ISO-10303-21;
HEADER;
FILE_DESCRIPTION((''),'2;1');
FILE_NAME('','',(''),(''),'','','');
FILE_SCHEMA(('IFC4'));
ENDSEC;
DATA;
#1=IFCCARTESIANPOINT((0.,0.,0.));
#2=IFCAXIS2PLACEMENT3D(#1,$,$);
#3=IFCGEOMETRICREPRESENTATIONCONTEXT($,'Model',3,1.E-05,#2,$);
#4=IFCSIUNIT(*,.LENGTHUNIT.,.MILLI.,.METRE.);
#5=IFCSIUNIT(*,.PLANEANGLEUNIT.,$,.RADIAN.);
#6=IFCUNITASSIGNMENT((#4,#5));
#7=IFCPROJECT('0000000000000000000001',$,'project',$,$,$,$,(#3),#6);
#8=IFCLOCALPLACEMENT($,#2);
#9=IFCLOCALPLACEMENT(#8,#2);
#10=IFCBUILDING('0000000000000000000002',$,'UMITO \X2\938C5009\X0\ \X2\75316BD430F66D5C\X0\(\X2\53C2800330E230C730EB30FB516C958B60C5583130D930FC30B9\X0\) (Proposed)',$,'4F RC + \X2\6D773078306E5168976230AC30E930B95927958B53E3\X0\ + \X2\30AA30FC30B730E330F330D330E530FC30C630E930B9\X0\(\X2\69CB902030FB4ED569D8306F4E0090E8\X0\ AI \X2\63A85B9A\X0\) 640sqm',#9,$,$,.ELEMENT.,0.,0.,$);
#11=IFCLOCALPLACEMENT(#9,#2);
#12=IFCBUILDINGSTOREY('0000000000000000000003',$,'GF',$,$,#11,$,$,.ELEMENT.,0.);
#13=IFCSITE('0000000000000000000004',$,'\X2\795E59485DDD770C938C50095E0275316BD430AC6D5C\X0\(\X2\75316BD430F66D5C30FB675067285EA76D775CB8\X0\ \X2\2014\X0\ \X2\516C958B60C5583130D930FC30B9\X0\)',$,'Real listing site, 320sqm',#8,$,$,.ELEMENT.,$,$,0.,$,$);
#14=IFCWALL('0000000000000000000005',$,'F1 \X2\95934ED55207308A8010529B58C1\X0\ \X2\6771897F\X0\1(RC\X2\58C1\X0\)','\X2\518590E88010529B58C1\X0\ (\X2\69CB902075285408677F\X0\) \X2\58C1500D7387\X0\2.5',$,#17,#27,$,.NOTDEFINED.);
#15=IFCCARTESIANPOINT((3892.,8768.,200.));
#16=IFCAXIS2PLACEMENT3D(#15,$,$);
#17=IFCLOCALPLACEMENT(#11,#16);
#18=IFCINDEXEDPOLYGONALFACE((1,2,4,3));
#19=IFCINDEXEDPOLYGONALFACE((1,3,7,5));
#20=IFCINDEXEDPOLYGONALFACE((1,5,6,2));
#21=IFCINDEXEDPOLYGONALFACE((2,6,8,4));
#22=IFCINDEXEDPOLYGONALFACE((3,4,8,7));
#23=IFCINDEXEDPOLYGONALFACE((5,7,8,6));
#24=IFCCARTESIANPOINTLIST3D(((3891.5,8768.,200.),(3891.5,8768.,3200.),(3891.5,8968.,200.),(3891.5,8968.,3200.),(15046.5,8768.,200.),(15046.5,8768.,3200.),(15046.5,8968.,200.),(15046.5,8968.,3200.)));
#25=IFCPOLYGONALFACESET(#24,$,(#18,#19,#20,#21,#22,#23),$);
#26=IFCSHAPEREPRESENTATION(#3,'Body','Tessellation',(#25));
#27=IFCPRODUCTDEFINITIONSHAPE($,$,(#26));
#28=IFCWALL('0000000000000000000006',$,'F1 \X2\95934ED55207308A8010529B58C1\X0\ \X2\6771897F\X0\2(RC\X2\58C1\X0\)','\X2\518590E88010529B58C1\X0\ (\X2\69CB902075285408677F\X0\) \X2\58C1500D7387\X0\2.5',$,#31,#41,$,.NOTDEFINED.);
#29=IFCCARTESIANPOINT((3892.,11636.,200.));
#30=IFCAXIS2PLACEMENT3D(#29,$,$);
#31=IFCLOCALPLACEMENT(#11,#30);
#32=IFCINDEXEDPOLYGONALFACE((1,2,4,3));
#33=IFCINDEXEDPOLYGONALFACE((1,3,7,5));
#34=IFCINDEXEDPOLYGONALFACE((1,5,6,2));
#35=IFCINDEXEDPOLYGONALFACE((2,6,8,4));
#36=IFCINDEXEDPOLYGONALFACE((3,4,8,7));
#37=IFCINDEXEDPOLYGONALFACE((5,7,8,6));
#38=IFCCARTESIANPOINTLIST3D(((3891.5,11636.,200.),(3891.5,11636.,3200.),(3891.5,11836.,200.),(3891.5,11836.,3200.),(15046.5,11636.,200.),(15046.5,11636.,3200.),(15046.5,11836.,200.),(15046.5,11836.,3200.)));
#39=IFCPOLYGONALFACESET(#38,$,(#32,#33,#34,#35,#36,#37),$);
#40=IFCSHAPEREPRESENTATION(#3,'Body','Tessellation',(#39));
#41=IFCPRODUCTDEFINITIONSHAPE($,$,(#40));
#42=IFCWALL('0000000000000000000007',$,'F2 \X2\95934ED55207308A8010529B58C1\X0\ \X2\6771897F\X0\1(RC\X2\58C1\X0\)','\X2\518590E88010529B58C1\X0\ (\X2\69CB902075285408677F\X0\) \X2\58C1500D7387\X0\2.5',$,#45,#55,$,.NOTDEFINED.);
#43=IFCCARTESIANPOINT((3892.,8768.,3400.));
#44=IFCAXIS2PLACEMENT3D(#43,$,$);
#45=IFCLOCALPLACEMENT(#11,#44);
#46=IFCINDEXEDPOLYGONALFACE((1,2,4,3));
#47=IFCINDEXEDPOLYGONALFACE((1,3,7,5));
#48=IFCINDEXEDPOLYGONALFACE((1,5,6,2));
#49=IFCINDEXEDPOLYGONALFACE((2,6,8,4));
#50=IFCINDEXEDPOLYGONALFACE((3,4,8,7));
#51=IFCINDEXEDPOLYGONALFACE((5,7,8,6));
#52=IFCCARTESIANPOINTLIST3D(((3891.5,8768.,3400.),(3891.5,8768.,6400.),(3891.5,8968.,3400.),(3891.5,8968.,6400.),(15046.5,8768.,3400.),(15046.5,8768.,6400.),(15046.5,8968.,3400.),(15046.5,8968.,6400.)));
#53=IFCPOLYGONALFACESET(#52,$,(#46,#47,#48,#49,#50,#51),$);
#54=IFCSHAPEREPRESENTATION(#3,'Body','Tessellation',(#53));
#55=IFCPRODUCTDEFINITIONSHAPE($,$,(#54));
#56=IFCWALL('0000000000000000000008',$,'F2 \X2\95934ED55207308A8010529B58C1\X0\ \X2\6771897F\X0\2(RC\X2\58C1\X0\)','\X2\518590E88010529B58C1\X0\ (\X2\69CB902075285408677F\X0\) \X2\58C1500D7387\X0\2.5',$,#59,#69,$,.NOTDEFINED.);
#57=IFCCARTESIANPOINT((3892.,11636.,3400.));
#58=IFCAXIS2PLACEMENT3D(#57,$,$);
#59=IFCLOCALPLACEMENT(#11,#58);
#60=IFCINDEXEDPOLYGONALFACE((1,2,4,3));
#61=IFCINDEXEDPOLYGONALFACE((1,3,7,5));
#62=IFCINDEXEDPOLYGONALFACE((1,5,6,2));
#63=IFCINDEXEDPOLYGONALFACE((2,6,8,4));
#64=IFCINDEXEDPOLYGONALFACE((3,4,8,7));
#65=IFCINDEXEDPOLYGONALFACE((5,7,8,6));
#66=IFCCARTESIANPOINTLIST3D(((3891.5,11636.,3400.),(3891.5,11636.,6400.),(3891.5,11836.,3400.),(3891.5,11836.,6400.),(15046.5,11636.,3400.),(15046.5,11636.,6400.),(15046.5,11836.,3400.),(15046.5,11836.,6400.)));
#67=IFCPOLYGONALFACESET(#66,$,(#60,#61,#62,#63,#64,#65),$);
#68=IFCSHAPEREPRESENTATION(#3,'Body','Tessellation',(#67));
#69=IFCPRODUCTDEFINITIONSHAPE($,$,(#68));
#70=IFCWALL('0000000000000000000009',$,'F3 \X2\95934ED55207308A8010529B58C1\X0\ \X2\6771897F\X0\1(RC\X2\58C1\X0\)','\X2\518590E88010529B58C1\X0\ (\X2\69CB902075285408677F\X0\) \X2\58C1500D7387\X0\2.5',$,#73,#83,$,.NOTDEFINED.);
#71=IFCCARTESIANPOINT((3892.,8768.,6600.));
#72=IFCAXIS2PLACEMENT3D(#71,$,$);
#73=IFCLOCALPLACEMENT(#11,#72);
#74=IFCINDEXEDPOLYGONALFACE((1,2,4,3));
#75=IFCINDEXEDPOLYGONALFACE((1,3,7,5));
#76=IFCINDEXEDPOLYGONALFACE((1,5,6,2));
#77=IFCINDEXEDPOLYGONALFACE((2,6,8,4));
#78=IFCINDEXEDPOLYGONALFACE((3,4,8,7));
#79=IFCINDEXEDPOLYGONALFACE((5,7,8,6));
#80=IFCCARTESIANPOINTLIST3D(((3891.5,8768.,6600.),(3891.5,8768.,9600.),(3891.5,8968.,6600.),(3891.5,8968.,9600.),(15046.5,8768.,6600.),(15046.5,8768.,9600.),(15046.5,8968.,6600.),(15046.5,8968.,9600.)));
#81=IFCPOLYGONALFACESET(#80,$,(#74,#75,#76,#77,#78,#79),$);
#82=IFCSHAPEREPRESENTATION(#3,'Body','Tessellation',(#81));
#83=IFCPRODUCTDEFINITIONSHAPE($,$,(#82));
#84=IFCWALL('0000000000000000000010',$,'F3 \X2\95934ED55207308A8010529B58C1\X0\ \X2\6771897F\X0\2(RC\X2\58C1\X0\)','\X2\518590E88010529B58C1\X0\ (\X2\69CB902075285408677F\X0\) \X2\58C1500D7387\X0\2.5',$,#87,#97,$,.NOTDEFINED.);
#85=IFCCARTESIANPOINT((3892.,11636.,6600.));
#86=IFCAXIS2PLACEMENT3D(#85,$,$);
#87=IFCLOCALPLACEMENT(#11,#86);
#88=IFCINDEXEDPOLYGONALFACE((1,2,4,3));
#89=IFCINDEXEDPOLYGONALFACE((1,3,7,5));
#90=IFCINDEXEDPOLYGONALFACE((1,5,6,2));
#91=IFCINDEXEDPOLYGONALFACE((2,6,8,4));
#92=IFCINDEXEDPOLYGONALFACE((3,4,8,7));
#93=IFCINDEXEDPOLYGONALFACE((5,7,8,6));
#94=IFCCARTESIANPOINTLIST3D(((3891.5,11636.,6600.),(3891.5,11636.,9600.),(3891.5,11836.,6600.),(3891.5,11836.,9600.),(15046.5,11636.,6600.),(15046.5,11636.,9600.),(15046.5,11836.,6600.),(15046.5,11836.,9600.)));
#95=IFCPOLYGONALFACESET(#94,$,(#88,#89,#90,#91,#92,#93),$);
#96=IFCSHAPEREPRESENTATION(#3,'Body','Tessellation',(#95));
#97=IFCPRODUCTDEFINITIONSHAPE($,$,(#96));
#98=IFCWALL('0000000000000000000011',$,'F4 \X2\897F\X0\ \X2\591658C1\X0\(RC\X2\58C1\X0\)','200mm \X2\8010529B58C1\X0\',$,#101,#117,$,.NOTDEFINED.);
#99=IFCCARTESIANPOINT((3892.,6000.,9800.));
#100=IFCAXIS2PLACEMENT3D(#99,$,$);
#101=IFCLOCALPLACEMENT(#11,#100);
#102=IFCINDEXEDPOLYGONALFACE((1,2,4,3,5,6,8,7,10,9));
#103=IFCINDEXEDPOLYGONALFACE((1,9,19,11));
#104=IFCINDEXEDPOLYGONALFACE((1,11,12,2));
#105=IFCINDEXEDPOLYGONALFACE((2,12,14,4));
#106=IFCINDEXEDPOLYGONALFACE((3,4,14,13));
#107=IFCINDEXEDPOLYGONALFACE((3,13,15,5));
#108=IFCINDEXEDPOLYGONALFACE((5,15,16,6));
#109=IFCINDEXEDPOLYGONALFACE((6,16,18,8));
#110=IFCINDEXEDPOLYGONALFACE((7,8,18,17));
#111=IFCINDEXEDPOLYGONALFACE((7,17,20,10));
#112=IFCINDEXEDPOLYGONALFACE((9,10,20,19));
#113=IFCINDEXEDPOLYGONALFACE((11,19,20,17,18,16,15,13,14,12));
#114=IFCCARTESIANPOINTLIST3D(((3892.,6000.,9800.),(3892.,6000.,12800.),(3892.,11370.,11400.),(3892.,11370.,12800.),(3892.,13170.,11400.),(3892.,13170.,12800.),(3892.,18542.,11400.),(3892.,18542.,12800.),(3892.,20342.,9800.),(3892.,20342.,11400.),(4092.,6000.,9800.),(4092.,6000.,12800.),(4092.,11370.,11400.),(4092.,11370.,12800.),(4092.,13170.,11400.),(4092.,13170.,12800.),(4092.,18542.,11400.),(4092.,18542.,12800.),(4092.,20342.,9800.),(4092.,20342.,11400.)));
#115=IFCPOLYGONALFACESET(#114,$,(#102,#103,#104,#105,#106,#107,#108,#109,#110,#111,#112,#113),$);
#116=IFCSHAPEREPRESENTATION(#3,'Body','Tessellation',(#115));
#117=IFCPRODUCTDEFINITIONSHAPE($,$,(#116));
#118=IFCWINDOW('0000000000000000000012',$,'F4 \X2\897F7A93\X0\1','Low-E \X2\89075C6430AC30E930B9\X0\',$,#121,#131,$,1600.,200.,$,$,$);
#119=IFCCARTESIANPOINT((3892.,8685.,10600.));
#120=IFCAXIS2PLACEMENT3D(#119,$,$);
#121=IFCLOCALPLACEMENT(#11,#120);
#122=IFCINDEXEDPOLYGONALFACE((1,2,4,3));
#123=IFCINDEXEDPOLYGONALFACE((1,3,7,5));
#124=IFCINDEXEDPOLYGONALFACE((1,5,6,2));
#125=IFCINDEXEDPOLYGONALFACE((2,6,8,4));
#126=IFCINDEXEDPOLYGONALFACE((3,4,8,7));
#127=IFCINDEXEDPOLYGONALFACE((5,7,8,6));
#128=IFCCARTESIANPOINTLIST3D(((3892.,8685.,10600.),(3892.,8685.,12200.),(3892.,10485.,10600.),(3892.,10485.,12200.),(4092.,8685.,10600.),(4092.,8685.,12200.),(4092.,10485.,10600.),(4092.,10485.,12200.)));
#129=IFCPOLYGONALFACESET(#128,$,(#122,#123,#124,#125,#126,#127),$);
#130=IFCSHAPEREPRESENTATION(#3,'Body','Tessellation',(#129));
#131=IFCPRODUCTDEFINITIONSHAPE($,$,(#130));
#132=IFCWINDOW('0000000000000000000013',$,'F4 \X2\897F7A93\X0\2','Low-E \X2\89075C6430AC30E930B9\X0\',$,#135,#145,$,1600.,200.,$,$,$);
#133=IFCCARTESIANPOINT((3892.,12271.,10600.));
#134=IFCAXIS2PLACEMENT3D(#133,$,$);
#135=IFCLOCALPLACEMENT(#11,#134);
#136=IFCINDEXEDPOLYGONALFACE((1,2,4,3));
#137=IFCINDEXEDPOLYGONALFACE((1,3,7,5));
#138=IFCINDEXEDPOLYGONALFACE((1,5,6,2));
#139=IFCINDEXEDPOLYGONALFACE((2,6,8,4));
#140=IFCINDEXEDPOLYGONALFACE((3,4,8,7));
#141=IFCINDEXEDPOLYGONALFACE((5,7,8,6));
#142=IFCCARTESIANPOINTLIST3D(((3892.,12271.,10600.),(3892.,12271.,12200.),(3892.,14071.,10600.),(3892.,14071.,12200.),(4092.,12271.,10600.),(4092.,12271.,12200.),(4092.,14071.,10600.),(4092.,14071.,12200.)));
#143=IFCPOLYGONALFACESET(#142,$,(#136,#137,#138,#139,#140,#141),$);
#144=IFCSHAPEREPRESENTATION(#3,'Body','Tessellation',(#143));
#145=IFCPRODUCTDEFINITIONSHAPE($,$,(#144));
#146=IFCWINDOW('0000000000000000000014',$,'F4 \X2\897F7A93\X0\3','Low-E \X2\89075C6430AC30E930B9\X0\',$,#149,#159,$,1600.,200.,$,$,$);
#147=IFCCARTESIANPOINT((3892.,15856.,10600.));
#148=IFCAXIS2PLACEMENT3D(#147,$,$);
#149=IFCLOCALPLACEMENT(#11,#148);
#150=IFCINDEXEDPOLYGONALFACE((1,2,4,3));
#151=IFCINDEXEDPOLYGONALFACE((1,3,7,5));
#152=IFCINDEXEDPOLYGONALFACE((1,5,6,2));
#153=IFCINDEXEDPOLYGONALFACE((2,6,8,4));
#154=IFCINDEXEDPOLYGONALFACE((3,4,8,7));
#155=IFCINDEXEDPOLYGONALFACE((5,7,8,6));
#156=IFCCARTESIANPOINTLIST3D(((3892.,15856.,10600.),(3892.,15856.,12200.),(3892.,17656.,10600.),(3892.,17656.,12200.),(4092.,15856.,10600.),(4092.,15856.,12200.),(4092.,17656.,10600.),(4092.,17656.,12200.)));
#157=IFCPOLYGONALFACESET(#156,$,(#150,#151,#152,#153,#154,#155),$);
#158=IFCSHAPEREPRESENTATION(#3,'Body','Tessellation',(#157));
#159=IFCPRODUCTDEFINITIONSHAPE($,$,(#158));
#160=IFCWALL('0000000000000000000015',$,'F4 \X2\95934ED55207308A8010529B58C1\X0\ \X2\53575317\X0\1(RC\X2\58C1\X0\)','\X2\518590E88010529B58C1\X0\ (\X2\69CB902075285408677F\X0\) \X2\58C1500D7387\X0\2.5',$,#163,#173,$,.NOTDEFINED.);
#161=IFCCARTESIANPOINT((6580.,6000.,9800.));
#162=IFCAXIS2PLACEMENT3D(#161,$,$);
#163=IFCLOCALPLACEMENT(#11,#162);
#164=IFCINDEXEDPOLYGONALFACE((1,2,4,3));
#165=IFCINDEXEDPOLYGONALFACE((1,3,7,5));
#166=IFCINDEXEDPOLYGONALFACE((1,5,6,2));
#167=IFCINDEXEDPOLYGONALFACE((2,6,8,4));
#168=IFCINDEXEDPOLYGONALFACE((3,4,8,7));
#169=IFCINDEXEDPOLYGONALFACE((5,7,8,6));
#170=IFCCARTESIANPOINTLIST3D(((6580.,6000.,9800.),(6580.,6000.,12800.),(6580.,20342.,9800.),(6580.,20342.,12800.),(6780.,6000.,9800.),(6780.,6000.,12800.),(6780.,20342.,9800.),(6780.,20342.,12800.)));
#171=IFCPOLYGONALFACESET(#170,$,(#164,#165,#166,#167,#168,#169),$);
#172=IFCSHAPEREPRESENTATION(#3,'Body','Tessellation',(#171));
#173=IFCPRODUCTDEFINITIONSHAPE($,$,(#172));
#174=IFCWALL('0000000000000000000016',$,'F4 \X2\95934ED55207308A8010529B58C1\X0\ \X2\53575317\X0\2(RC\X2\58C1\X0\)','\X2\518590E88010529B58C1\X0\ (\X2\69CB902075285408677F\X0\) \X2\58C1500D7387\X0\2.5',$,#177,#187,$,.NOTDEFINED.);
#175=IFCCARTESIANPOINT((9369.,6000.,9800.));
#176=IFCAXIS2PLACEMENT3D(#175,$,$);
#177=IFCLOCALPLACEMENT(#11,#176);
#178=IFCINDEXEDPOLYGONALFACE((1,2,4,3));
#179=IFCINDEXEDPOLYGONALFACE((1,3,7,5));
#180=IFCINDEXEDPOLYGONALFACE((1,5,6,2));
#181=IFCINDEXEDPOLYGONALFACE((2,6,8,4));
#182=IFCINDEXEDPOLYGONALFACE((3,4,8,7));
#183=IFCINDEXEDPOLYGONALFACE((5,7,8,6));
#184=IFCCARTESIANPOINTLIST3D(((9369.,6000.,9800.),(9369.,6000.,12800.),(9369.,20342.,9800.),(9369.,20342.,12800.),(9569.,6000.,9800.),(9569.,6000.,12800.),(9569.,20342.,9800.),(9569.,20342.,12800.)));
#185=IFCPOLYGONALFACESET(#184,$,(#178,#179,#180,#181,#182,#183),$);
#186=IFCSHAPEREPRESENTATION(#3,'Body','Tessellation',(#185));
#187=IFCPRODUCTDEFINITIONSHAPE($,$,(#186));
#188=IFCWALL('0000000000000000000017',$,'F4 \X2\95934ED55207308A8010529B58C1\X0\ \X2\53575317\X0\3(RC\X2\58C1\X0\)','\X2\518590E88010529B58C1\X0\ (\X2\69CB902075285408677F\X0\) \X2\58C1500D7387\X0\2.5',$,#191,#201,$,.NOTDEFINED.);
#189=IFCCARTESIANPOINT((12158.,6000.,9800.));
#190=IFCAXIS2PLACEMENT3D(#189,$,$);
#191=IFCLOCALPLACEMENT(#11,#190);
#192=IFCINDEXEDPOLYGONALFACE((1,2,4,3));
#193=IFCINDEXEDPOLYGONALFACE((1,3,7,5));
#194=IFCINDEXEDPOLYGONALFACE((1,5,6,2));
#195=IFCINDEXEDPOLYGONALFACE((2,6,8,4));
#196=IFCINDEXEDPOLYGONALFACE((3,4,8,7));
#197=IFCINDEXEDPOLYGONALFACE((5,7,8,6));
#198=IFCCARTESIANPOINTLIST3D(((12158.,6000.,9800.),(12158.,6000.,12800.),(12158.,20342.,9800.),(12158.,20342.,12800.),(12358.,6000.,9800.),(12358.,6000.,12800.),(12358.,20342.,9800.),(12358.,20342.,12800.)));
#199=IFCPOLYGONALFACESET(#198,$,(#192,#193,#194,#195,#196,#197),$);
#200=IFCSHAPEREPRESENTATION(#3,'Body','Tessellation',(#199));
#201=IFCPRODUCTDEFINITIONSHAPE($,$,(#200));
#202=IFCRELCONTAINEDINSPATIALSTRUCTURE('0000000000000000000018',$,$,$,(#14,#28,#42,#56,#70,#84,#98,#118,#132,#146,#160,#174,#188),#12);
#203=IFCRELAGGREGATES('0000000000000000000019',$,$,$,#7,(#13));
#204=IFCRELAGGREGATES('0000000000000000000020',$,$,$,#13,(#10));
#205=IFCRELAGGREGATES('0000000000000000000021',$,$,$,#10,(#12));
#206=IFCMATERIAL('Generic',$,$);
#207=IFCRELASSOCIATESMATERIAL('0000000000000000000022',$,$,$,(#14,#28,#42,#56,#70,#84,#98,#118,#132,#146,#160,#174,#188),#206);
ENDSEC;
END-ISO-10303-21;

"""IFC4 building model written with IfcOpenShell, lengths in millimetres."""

from ifc_helpers import new_model, si_unit, frame, frame_2d, origin, place, context, project, spatial, rectangle, extrude, material, element, fill, save


model = new_model("IFC4")

# Units and contexts
model_context = context("Model", 3, precision=1e-05, world=origin())
ifc_project = project(units=[si_unit("LENGTHUNIT", "METRE", prefix="MILLI"), si_unit("PLANEANGLEUNIT", "RADIAN")], contexts=[model_context])

# Site, building, storey
site_placement = place(None, origin())
site = spatial("IfcSite", under=ifc_project, at=site_placement, Name="神奈川県鎌倉市由比ガ浜(由比ヶ浜・材木座海岸 — 公開情報ベース)", ObjectType="Real listing site, 320sqm", CompositionType="ELEMENT", RefElevation=0.0)
building_placement = place(site_placement, origin())
building = spatial("IfcBuilding", under=site, at=building_placement, Name="UMITO 鎌倉 由比ヶ浜(参考モデル・公開情報ベース) (Proposed)", ObjectType="4F RC + 海への全面ガラス大開口 + オーシャンビューテラス(構造・仕様は一部 AI 推定) 640sqm", CompositionType="ELEMENT", ElevationOfRefHeight=0.0, ElevationOfTerrain=0.0)
storey_placement = place(building_placement, origin())
storey = spatial("IfcBuildingStorey", under=building, at=storey_placement, Name="GF", CompositionType="ELEMENT", Elevation=0.0)

# Walls
ifc_material_1 = material(Name="Generic")
wall_1_placement = place(storey_placement, frame((3892.0, 8768.0, 200.0)))
element("IfcWall", 1, at=wall_1_placement, inside=storey, material=ifc_material_1, Name="F1 間仕切り耐力壁 東西1(RC壁)", Description="内部耐力壁 (構造用合板) 壁倍率2.5", PredefinedType="NOTDEFINED", context=model_context, shape_type="SweptSolid", body=[
    extrude(rectangle(XDim=11155.0, YDim=200.0, at=frame_2d((5577.0, 100.0))), frame((3892.0, 8768.0, 200.0)), (0.0, 0.0, 1.0), 3000.0),
])
wall_2_placement = place(storey_placement, frame((3892.0, 11636.0, 200.0)))
element("IfcWall", 2, at=wall_2_placement, inside=storey, material=ifc_material_1, Name="F1 間仕切り耐力壁 東西2(RC壁)", Description="内部耐力壁 (構造用合板) 壁倍率2.5", PredefinedType="NOTDEFINED", context=model_context, shape_type="SweptSolid", body=[
    extrude(rectangle(XDim=11155.0, YDim=200.0, at=frame_2d((5577.0, 100.0))), frame((3892.0, 11636.0, 200.0)), (0.0, 0.0, 1.0), 3000.0),
])
wall_3_placement = place(storey_placement, frame((3892.0, 8768.0, 3400.0)))
element("IfcWall", 3, at=wall_3_placement, inside=storey, material=ifc_material_1, Name="F2 間仕切り耐力壁 東西1(RC壁)", Description="内部耐力壁 (構造用合板) 壁倍率2.5", PredefinedType="NOTDEFINED", context=model_context, shape_type="SweptSolid", body=[
    extrude(rectangle(XDim=11155.0, YDim=200.0, at=frame_2d((5577.0, 100.0))), frame((3892.0, 8768.0, 3400.0)), (0.0, 0.0, 1.0), 3000.0),
])
wall_4_placement = place(storey_placement, frame((3892.0, 11636.0, 3400.0)))
element("IfcWall", 4, at=wall_4_placement, inside=storey, material=ifc_material_1, Name="F2 間仕切り耐力壁 東西2(RC壁)", Description="内部耐力壁 (構造用合板) 壁倍率2.5", PredefinedType="NOTDEFINED", context=model_context, shape_type="SweptSolid", body=[
    extrude(rectangle(XDim=11155.0, YDim=200.0, at=frame_2d((5577.0, 100.0))), frame((3892.0, 11636.0, 3400.0)), (0.0, 0.0, 1.0), 3000.0),
])
wall_5_placement = place(storey_placement, frame((3892.0, 8768.0, 6600.0)))
element("IfcWall", 5, at=wall_5_placement, inside=storey, material=ifc_material_1, Name="F3 間仕切り耐力壁 東西1(RC壁)", Description="内部耐力壁 (構造用合板) 壁倍率2.5", PredefinedType="NOTDEFINED", context=model_context, shape_type="SweptSolid", body=[
    extrude(rectangle(XDim=11155.0, YDim=200.0, at=frame_2d((5577.0, 100.0))), frame((3892.0, 8768.0, 6600.0)), (0.0, 0.0, 1.0), 3000.0),
])
wall_6_placement = place(storey_placement, frame((3892.0, 11636.0, 6600.0)))
element("IfcWall", 6, at=wall_6_placement, inside=storey, material=ifc_material_1, Name="F3 間仕切り耐力壁 東西2(RC壁)", Description="内部耐力壁 (構造用合板) 壁倍率2.5", PredefinedType="NOTDEFINED", context=model_context, shape_type="SweptSolid", body=[
    extrude(rectangle(XDim=11155.0, YDim=200.0, at=frame_2d((5577.0, 100.0))), frame((3892.0, 11636.0, 6600.0)), (0.0, 0.0, 1.0), 3000.0),
])

# Wall, openings, windows
wall_7_placement = place(storey_placement, frame((3892.0, 6000.0, 9800.0)))
wall_7 = element("IfcWall", 7, at=wall_7_placement, inside=storey, material=ifc_material_1, Name="F4 西 外壁(RC壁)", Description="200mm 耐力壁", PredefinedType="NOTDEFINED", context=model_context, shape_type="SweptSolid", body=[
    extrude(rectangle(XDim=200.0, YDim=14342.0, at=frame_2d((100.0, 7171.0))), frame((3892.0, 6000.0, 9800.0)), (0.0, 0.0, 1.0), 3000.0),
])
opening_1_placement = place(storey_placement, frame((3892.0, 8685.0, 10600.0)))
opening_1 = element("IfcOpeningElement", 8, at=opening_1_placement, cuts=wall_7, PredefinedType="NOTDEFINED", context=model_context, shape_type="SweptSolid", body=[
    extrude(rectangle(XDim=200.0, YDim=1800.0, at=frame_2d((100.0, 900.0))), frame((3892.0, 8685.0, 10600.0)), (0.0, 0.0, 1.0), 1600.0),
])
opening_2_placement = place(storey_placement, frame((3892.0, 12271.0, 10600.0)))
opening_2 = element("IfcOpeningElement", 9, at=opening_2_placement, cuts=wall_7, PredefinedType="NOTDEFINED", context=model_context, shape_type="SweptSolid", body=[
    extrude(rectangle(XDim=200.0, YDim=1800.0, at=frame_2d((100.0, 900.0))), frame((3892.0, 12271.0, 10600.0)), (0.0, 0.0, 1.0), 1600.0),
])
opening_3_placement = place(storey_placement, frame((3892.0, 15856.0, 10600.0)))
opening_3 = element("IfcOpeningElement", 10, at=opening_3_placement, cuts=wall_7, PredefinedType="NOTDEFINED", context=model_context, shape_type="SweptSolid", body=[
    extrude(rectangle(XDim=200.0, YDim=1800.0, at=frame_2d((100.0, 900.0))), frame((3892.0, 15856.0, 10600.0)), (0.0, 0.0, 1.0), 1600.0),
])
window_1_placement = place(storey_placement, frame((3892.0, 8685.0, 10600.0)))
window_1 = element("IfcWindow", 11, at=window_1_placement, inside=storey, material=ifc_material_1, Name="F4 西窓1", Description="Low-E 複層ガラス", OverallHeight=1600.0, OverallWidth=200.0, context=model_context, shape_type="SweptSolid", body=[
    extrude(rectangle(XDim=200.0, YDim=1800.0, at=frame_2d((100.0, 900.0))), frame((3892.0, 8685.0, 10600.0)), (0.0, 0.0, 1.0), 1600.0),
])
fill(opening_1, window_1)
window_2_placement = place(storey_placement, frame((3892.0, 12271.0, 10600.0)))
window_2 = element("IfcWindow", 12, at=window_2_placement, inside=storey, material=ifc_material_1, Name="F4 西窓2", Description="Low-E 複層ガラス", OverallHeight=1600.0, OverallWidth=200.0, context=model_context, shape_type="SweptSolid", body=[
    extrude(rectangle(XDim=200.0, YDim=1800.0, at=frame_2d((100.0, 900.0))), frame((3892.0, 12271.0, 10600.0)), (0.0, 0.0, 1.0), 1600.0),
])
fill(opening_2, window_2)
window_3_placement = place(storey_placement, frame((3892.0, 15856.0, 10600.0)))
window_3 = element("IfcWindow", 13, at=window_3_placement, inside=storey, material=ifc_material_1, Name="F4 西窓3", Description="Low-E 複層ガラス", OverallHeight=1600.0, OverallWidth=200.0, context=model_context, shape_type="SweptSolid", body=[
    extrude(rectangle(XDim=200.0, YDim=1800.0, at=frame_2d((100.0, 900.0))), frame((3892.0, 15856.0, 10600.0)), (0.0, 0.0, 1.0), 1600.0),
])
fill(opening_3, window_3)

# Walls
wall_8_placement = place(storey_placement, frame((6580.0, 6000.0, 9800.0)))
element("IfcWall", 14, at=wall_8_placement, inside=storey, material=ifc_material_1, Name="F4 間仕切り耐力壁 南北1(RC壁)", Description="内部耐力壁 (構造用合板) 壁倍率2.5", PredefinedType="NOTDEFINED", context=model_context, shape_type="SweptSolid", body=[
    extrude(rectangle(XDim=200.0, YDim=14342.0, at=frame_2d((100.0, 7171.0))), frame((6580.0, 6000.0, 9800.0)), (0.0, 0.0, 1.0), 3000.0),
])
wall_9_placement = place(storey_placement, frame((9369.0, 6000.0, 9800.0)))
element("IfcWall", 15, at=wall_9_placement, inside=storey, material=ifc_material_1, Name="F4 間仕切り耐力壁 南北2(RC壁)", Description="内部耐力壁 (構造用合板) 壁倍率2.5", PredefinedType="NOTDEFINED", context=model_context, shape_type="SweptSolid", body=[
    extrude(rectangle(XDim=200.0, YDim=14342.0, at=frame_2d((100.0, 7171.0))), frame((9369.0, 6000.0, 9800.0)), (0.0, 0.0, 1.0), 3000.0),
])
wall_10_placement = place(storey_placement, frame((12158.0, 6000.0, 9800.0)))
element("IfcWall", 16, at=wall_10_placement, inside=storey, material=ifc_material_1, Name="F4 間仕切り耐力壁 南北3(RC壁)", Description="内部耐力壁 (構造用合板) 壁倍率2.5", PredefinedType="NOTDEFINED", context=model_context, shape_type="SweptSolid", body=[
    extrude(rectangle(XDim=200.0, YDim=14342.0, at=frame_2d((100.0, 7171.0))), frame((12158.0, 6000.0, 9800.0)), (0.0, 0.0, 1.0), 3000.0),
])

save(model, "model.ifc")
